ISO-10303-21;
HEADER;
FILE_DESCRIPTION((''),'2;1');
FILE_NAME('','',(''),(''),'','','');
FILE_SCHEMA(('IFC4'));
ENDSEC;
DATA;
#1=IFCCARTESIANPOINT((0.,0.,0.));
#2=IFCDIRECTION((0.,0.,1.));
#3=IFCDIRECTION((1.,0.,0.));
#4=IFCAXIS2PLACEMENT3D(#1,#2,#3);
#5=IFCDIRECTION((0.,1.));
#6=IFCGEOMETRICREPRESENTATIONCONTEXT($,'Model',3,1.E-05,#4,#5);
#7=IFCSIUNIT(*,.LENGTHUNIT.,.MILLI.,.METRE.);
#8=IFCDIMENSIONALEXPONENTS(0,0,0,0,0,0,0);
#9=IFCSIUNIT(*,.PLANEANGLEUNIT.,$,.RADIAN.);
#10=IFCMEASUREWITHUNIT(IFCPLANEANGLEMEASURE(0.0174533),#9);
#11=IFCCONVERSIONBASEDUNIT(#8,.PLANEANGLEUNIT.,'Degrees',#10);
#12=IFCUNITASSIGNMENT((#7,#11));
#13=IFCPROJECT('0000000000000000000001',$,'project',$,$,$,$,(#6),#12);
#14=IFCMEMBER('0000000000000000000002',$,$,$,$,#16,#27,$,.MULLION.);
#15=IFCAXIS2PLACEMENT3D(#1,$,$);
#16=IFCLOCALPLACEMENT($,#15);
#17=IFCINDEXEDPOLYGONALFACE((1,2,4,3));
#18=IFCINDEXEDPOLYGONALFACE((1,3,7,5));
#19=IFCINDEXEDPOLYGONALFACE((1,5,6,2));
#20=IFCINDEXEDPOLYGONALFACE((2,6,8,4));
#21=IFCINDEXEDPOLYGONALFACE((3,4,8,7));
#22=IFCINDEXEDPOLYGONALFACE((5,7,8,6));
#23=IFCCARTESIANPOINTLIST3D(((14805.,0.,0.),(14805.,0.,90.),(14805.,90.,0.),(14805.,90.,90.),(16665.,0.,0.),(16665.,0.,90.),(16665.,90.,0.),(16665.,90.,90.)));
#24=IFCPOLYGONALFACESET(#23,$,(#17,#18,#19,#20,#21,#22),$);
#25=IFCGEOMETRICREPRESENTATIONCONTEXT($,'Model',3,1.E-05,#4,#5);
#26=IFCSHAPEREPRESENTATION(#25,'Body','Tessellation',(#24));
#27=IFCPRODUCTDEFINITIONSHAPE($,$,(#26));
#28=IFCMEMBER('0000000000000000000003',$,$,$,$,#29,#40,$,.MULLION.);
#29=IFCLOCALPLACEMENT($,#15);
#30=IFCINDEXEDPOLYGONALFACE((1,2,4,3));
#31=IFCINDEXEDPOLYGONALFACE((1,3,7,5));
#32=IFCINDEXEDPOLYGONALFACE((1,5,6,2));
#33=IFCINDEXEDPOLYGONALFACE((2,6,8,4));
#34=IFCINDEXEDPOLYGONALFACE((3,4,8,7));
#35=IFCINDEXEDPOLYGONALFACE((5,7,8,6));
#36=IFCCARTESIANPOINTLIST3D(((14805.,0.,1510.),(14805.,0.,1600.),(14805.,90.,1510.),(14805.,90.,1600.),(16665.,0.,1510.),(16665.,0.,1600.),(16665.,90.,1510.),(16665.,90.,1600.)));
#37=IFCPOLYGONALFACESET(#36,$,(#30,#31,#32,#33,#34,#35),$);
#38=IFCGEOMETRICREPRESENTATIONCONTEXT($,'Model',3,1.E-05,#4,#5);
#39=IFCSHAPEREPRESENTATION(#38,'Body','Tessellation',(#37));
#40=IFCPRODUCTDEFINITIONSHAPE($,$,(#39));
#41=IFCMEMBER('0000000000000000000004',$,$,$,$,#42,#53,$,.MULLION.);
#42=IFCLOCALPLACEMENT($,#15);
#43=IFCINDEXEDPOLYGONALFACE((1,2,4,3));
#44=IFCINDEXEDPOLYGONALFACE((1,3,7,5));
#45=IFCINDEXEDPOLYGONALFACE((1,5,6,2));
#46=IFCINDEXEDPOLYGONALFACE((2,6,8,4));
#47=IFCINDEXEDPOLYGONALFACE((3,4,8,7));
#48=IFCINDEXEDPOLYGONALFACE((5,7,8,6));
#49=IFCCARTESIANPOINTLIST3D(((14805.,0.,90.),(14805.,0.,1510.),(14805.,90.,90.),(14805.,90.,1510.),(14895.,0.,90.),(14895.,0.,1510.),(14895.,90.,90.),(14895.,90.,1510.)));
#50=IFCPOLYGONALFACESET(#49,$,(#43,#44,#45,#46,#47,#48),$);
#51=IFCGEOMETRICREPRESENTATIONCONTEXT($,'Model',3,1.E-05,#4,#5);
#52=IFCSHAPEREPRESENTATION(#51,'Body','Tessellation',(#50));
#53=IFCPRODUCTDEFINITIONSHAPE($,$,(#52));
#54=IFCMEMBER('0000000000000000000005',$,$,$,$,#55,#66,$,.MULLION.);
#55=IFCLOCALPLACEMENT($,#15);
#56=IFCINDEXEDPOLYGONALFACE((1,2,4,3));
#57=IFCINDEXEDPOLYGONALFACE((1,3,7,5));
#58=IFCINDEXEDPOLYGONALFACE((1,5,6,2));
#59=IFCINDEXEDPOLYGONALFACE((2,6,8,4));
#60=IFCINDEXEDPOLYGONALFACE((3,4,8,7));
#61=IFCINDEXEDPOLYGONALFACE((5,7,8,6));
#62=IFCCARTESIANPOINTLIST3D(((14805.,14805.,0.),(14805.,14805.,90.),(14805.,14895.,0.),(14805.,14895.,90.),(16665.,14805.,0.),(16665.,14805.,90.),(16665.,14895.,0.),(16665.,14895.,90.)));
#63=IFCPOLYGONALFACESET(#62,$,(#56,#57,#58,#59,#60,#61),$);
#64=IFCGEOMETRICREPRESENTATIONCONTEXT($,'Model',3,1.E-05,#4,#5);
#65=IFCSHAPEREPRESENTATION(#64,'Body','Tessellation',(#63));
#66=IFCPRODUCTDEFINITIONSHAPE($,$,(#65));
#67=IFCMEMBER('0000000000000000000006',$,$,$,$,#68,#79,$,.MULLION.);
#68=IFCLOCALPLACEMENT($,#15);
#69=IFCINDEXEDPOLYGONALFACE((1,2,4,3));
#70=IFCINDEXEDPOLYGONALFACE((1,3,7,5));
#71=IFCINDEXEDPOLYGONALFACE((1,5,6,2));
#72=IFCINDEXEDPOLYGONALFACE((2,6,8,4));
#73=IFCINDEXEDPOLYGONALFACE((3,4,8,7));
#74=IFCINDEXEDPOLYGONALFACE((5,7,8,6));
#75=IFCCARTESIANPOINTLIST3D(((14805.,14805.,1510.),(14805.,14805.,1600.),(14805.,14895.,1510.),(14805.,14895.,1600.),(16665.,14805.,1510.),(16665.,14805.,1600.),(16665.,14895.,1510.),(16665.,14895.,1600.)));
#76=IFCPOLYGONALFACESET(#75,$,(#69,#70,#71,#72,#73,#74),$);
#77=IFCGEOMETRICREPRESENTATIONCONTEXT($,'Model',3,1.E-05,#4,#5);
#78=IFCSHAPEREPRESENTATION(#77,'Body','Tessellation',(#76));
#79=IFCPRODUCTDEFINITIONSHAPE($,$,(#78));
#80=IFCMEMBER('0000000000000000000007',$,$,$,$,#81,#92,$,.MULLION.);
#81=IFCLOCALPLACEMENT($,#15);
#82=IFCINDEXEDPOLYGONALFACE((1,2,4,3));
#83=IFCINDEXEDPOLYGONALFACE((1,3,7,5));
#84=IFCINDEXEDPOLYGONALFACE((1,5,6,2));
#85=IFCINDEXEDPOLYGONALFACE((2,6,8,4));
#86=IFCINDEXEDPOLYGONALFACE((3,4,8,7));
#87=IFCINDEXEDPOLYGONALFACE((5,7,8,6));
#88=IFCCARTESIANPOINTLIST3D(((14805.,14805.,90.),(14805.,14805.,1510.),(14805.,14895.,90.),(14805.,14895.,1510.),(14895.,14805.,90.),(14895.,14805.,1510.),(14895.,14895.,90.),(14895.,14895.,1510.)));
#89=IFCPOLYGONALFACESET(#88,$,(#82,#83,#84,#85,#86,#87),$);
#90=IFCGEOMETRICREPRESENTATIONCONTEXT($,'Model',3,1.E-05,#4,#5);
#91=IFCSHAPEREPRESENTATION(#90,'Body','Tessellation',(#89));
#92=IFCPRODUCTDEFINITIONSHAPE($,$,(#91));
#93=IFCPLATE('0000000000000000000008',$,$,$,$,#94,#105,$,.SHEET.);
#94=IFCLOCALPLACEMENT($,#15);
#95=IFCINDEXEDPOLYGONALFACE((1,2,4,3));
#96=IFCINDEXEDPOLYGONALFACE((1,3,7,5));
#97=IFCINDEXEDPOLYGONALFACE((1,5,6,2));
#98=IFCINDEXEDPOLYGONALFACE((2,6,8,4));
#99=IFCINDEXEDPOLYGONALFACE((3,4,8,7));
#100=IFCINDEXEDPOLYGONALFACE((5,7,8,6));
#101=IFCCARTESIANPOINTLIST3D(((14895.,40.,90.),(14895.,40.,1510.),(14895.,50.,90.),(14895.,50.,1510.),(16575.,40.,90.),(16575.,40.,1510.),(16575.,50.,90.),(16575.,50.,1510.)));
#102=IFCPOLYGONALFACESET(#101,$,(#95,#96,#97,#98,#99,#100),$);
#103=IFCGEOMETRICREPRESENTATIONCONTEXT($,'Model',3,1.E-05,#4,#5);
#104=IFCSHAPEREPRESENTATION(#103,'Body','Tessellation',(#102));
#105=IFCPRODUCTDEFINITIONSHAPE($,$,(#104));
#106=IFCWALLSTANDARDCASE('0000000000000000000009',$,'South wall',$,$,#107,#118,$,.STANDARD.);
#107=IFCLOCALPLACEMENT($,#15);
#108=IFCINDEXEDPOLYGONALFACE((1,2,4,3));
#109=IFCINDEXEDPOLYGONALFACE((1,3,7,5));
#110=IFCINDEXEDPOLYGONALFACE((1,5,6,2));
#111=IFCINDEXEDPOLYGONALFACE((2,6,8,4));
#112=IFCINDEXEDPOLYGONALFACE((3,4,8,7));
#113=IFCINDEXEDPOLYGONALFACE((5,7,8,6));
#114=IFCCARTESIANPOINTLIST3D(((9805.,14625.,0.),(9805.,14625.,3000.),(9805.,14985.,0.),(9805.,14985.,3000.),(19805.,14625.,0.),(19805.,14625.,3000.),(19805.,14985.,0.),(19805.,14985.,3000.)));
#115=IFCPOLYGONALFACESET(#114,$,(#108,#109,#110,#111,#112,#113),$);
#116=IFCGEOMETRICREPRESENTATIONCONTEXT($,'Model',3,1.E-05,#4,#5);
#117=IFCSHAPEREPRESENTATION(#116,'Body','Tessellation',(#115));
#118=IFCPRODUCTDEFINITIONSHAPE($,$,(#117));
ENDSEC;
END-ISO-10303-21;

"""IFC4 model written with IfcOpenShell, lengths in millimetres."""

from ifc_helpers import new_model, entity, si_unit, converted_unit, direction, frame, origin_with_axes, place, context, project, polyline, outline, extrude, source, transform, mapped, element, save


model = new_model("IFC4")

# Units and contexts
model_context_1 = context("Model", 3, precision=1e-05, world=origin_with_axes(), true_north=direction((0.0, 1.0)))
model_context_2 = context("Model", 3, precision=1e-05, world=origin_with_axes(), true_north=direction((0.0, 1.0)))
model_context_3 = context("Model", 3, precision=1e-05, world=origin_with_axes(), true_north=direction((0.0, 1.0)))
model_context_4 = context("Model", 3, precision=1e-05, world=origin_with_axes(), true_north=direction((0.0, 1.0)))
model_context_5 = context("Model", 3, precision=1e-05, world=origin_with_axes(), true_north=direction((0.0, 1.0)))
model_context_6 = context("Model", 3, precision=1e-05, world=origin_with_axes(), true_north=direction((0.0, 1.0)))
model_context_7 = context("Model", 3, precision=1e-05, world=origin_with_axes(), true_north=direction((0.0, 1.0)))
model_context_8 = context("Model", 3, precision=1e-05, world=origin_with_axes(), true_north=direction((0.0, 1.0)))
model_context_9 = context("Model", 3, precision=1e-05, world=origin_with_axes(), true_north=direction((0.0, 1.0)))
ifc_project = project(units=[si_unit("LENGTHUNIT", "METRE", prefix="MILLI"), converted_unit("PLANEANGLEUNIT", "Degrees", entity("IfcPlaneAngleMeasure", 0.0174533), si_unit("PLANEANGLEUNIT", "RADIAN"), dimensions=[0, 0, 0, 0, 0, 0, 0])], contexts=[model_context_1])

# Members
shared_shape_1 = source(origin_with_axes(), model_context_2, "Body", "SweptSolid", [
    extrude(outline(polyline([(-930.0, -45.0), (930.0, -45.0), (930.0, 45.0), (-930.0, 45.0), (-930.0, -45.0), (-930.0, -45.0)])), origin_with_axes(), (0.0, 0.0, 1.0), 90.0),
])
placement_1 = place(None, frame((14805.0, 0.0, 0.0)))
member_1_placement = place(placement_1, frame((930.0, 45.0, 0.0), z_axis=(0.0, 0.0, 1.0), x_axis=(1.0, 0.0, 0.0)))
element("IfcMember", 1, at=member_1_placement, PredefinedType="MULLION", context=model_context_2, shape_type="MappedRepresentation", body=[
    mapped(shared_shape_1, transform((0.0, 0.0, 0.0))),
])
shared_shape_2 = source(origin_with_axes(), model_context_3, "Body", "SweptSolid", [
    extrude(outline(polyline([(-930.0, -45.0), (930.0, -45.0), (930.0, 45.0), (-930.0, 45.0), (-930.0, -45.0), (-930.0, -45.0)])), origin_with_axes(), (0.0, 0.0, 1.0), 90.0),
])
member_2_placement = place(placement_1, frame((930.0, 45.0, 1510.0), z_axis=(0.0, 0.0, 1.0), x_axis=(1.0, 0.0, 0.0)))
element("IfcMember", 2, at=member_2_placement, PredefinedType="MULLION", context=model_context_3, shape_type="MappedRepresentation", body=[
    mapped(shared_shape_2, transform((0.0, 0.0, 0.0))),
])
shared_shape_3 = source(origin_with_axes(), model_context_4, "Body", "SweptSolid", [
    extrude(outline(polyline([(-45.0, -45.0), (45.0, -45.0), (45.0, 45.0), (-45.0, 45.0), (-45.0, -45.0), (-45.0, -45.0)])), origin_with_axes(), (0.0, 0.0, 1.0), 1420.0),
])
member_3_placement = place(placement_1, frame((45.0, 45.0, 90.0), z_axis=(0.0, 0.0, 1.0), x_axis=(1.0, 0.0, 0.0)))
element("IfcMember", 3, at=member_3_placement, PredefinedType="MULLION", context=model_context_4, shape_type="MappedRepresentation", body=[
    mapped(shared_shape_3, transform((0.0, 0.0, 0.0))),
])
shared_shape_4 = source(origin_with_axes(), model_context_6, "Body", "SweptSolid", [
    extrude(outline(polyline([(-930.0, -45.0), (930.0, -45.0), (930.0, 45.0), (-930.0, 45.0), (-930.0, -45.0), (-930.0, -45.0)])), origin_with_axes(), (0.0, 0.0, 1.0), 90.0),
])
placement_2 = place(None, frame((14805.0, 14805.0, 0.0)))
member_4_placement = place(placement_2, frame((930.0, 45.0, 0.0), z_axis=(0.0, 0.0, 1.0), x_axis=(1.0, 0.0, 0.0)))
element("IfcMember", 4, at=member_4_placement, PredefinedType="MULLION", context=model_context_6, shape_type="MappedRepresentation", body=[
    mapped(shared_shape_4, transform((0.0, 0.0, 0.0))),
])
shared_shape_5 = source(origin_with_axes(), model_context_7, "Body", "SweptSolid", [
    extrude(outline(polyline([(-930.0, -45.0), (930.0, -45.0), (930.0, 45.0), (-930.0, 45.0), (-930.0, -45.0), (-930.0, -45.0)])), origin_with_axes(), (0.0, 0.0, 1.0), 90.0),
])
member_5_placement = place(placement_2, frame((930.0, 45.0, 1510.0), z_axis=(0.0, 0.0, 1.0), x_axis=(1.0, 0.0, 0.0)))
element("IfcMember", 5, at=member_5_placement, PredefinedType="MULLION", context=model_context_7, shape_type="MappedRepresentation", body=[
    mapped(shared_shape_5, transform((0.0, 0.0, 0.0))),
])
shared_shape_6 = source(origin_with_axes(), model_context_8, "Body", "SweptSolid", [
    extrude(outline(polyline([(-45.0, -45.0), (45.0, -45.0), (45.0, 45.0), (-45.0, 45.0), (-45.0, -45.0), (-45.0, -45.0)])), origin_with_axes(), (0.0, 0.0, 1.0), 1420.0),
])
member_6_placement = place(placement_2, frame((45.0, 45.0, 90.0), z_axis=(0.0, 0.0, 1.0), x_axis=(1.0, 0.0, 0.0)))
element("IfcMember", 6, at=member_6_placement, PredefinedType="MULLION", context=model_context_8, shape_type="MappedRepresentation", body=[
    mapped(shared_shape_6, transform((0.0, 0.0, 0.0))),
])

# Plate
plate_1_placement = place(placement_1, frame((930.0, 45.0, 90.0), z_axis=(0.0, 0.0, 1.0), x_axis=(1.0, 0.0, 0.0)))
element("IfcPlate", 7, at=plate_1_placement, PredefinedType="SHEET", context=model_context_5, shape_type="SweptSolid", body=[
    extrude(outline(polyline([(-840.0, -5.0), (840.0, -5.0), (840.0, 5.0), (-840.0, 5.0), (-840.0, -5.0), (-840.0, -5.0)])), origin_with_axes(), (0.0, 0.0, 1.0), 1420.0),
])

# Wall
wall_placement = place(placement_2, origin_with_axes())
element("IfcWallStandardCase", 8, at=wall_placement, Name="South wall", PredefinedType="STANDARD", context=model_context_9, shape_type="SweptSolid", body=[
    extrude(outline(polyline([(-5000.0, -180.0), (5000.0, -180.0), (5000.0, 180.0), (-5000.0, 180.0), (-5000.0, -180.0), (-5000.0, -180.0)])), origin_with_axes(), (0.0, 0.0, 1.0), 3000.0),
])

save(model, "model.ifc")
